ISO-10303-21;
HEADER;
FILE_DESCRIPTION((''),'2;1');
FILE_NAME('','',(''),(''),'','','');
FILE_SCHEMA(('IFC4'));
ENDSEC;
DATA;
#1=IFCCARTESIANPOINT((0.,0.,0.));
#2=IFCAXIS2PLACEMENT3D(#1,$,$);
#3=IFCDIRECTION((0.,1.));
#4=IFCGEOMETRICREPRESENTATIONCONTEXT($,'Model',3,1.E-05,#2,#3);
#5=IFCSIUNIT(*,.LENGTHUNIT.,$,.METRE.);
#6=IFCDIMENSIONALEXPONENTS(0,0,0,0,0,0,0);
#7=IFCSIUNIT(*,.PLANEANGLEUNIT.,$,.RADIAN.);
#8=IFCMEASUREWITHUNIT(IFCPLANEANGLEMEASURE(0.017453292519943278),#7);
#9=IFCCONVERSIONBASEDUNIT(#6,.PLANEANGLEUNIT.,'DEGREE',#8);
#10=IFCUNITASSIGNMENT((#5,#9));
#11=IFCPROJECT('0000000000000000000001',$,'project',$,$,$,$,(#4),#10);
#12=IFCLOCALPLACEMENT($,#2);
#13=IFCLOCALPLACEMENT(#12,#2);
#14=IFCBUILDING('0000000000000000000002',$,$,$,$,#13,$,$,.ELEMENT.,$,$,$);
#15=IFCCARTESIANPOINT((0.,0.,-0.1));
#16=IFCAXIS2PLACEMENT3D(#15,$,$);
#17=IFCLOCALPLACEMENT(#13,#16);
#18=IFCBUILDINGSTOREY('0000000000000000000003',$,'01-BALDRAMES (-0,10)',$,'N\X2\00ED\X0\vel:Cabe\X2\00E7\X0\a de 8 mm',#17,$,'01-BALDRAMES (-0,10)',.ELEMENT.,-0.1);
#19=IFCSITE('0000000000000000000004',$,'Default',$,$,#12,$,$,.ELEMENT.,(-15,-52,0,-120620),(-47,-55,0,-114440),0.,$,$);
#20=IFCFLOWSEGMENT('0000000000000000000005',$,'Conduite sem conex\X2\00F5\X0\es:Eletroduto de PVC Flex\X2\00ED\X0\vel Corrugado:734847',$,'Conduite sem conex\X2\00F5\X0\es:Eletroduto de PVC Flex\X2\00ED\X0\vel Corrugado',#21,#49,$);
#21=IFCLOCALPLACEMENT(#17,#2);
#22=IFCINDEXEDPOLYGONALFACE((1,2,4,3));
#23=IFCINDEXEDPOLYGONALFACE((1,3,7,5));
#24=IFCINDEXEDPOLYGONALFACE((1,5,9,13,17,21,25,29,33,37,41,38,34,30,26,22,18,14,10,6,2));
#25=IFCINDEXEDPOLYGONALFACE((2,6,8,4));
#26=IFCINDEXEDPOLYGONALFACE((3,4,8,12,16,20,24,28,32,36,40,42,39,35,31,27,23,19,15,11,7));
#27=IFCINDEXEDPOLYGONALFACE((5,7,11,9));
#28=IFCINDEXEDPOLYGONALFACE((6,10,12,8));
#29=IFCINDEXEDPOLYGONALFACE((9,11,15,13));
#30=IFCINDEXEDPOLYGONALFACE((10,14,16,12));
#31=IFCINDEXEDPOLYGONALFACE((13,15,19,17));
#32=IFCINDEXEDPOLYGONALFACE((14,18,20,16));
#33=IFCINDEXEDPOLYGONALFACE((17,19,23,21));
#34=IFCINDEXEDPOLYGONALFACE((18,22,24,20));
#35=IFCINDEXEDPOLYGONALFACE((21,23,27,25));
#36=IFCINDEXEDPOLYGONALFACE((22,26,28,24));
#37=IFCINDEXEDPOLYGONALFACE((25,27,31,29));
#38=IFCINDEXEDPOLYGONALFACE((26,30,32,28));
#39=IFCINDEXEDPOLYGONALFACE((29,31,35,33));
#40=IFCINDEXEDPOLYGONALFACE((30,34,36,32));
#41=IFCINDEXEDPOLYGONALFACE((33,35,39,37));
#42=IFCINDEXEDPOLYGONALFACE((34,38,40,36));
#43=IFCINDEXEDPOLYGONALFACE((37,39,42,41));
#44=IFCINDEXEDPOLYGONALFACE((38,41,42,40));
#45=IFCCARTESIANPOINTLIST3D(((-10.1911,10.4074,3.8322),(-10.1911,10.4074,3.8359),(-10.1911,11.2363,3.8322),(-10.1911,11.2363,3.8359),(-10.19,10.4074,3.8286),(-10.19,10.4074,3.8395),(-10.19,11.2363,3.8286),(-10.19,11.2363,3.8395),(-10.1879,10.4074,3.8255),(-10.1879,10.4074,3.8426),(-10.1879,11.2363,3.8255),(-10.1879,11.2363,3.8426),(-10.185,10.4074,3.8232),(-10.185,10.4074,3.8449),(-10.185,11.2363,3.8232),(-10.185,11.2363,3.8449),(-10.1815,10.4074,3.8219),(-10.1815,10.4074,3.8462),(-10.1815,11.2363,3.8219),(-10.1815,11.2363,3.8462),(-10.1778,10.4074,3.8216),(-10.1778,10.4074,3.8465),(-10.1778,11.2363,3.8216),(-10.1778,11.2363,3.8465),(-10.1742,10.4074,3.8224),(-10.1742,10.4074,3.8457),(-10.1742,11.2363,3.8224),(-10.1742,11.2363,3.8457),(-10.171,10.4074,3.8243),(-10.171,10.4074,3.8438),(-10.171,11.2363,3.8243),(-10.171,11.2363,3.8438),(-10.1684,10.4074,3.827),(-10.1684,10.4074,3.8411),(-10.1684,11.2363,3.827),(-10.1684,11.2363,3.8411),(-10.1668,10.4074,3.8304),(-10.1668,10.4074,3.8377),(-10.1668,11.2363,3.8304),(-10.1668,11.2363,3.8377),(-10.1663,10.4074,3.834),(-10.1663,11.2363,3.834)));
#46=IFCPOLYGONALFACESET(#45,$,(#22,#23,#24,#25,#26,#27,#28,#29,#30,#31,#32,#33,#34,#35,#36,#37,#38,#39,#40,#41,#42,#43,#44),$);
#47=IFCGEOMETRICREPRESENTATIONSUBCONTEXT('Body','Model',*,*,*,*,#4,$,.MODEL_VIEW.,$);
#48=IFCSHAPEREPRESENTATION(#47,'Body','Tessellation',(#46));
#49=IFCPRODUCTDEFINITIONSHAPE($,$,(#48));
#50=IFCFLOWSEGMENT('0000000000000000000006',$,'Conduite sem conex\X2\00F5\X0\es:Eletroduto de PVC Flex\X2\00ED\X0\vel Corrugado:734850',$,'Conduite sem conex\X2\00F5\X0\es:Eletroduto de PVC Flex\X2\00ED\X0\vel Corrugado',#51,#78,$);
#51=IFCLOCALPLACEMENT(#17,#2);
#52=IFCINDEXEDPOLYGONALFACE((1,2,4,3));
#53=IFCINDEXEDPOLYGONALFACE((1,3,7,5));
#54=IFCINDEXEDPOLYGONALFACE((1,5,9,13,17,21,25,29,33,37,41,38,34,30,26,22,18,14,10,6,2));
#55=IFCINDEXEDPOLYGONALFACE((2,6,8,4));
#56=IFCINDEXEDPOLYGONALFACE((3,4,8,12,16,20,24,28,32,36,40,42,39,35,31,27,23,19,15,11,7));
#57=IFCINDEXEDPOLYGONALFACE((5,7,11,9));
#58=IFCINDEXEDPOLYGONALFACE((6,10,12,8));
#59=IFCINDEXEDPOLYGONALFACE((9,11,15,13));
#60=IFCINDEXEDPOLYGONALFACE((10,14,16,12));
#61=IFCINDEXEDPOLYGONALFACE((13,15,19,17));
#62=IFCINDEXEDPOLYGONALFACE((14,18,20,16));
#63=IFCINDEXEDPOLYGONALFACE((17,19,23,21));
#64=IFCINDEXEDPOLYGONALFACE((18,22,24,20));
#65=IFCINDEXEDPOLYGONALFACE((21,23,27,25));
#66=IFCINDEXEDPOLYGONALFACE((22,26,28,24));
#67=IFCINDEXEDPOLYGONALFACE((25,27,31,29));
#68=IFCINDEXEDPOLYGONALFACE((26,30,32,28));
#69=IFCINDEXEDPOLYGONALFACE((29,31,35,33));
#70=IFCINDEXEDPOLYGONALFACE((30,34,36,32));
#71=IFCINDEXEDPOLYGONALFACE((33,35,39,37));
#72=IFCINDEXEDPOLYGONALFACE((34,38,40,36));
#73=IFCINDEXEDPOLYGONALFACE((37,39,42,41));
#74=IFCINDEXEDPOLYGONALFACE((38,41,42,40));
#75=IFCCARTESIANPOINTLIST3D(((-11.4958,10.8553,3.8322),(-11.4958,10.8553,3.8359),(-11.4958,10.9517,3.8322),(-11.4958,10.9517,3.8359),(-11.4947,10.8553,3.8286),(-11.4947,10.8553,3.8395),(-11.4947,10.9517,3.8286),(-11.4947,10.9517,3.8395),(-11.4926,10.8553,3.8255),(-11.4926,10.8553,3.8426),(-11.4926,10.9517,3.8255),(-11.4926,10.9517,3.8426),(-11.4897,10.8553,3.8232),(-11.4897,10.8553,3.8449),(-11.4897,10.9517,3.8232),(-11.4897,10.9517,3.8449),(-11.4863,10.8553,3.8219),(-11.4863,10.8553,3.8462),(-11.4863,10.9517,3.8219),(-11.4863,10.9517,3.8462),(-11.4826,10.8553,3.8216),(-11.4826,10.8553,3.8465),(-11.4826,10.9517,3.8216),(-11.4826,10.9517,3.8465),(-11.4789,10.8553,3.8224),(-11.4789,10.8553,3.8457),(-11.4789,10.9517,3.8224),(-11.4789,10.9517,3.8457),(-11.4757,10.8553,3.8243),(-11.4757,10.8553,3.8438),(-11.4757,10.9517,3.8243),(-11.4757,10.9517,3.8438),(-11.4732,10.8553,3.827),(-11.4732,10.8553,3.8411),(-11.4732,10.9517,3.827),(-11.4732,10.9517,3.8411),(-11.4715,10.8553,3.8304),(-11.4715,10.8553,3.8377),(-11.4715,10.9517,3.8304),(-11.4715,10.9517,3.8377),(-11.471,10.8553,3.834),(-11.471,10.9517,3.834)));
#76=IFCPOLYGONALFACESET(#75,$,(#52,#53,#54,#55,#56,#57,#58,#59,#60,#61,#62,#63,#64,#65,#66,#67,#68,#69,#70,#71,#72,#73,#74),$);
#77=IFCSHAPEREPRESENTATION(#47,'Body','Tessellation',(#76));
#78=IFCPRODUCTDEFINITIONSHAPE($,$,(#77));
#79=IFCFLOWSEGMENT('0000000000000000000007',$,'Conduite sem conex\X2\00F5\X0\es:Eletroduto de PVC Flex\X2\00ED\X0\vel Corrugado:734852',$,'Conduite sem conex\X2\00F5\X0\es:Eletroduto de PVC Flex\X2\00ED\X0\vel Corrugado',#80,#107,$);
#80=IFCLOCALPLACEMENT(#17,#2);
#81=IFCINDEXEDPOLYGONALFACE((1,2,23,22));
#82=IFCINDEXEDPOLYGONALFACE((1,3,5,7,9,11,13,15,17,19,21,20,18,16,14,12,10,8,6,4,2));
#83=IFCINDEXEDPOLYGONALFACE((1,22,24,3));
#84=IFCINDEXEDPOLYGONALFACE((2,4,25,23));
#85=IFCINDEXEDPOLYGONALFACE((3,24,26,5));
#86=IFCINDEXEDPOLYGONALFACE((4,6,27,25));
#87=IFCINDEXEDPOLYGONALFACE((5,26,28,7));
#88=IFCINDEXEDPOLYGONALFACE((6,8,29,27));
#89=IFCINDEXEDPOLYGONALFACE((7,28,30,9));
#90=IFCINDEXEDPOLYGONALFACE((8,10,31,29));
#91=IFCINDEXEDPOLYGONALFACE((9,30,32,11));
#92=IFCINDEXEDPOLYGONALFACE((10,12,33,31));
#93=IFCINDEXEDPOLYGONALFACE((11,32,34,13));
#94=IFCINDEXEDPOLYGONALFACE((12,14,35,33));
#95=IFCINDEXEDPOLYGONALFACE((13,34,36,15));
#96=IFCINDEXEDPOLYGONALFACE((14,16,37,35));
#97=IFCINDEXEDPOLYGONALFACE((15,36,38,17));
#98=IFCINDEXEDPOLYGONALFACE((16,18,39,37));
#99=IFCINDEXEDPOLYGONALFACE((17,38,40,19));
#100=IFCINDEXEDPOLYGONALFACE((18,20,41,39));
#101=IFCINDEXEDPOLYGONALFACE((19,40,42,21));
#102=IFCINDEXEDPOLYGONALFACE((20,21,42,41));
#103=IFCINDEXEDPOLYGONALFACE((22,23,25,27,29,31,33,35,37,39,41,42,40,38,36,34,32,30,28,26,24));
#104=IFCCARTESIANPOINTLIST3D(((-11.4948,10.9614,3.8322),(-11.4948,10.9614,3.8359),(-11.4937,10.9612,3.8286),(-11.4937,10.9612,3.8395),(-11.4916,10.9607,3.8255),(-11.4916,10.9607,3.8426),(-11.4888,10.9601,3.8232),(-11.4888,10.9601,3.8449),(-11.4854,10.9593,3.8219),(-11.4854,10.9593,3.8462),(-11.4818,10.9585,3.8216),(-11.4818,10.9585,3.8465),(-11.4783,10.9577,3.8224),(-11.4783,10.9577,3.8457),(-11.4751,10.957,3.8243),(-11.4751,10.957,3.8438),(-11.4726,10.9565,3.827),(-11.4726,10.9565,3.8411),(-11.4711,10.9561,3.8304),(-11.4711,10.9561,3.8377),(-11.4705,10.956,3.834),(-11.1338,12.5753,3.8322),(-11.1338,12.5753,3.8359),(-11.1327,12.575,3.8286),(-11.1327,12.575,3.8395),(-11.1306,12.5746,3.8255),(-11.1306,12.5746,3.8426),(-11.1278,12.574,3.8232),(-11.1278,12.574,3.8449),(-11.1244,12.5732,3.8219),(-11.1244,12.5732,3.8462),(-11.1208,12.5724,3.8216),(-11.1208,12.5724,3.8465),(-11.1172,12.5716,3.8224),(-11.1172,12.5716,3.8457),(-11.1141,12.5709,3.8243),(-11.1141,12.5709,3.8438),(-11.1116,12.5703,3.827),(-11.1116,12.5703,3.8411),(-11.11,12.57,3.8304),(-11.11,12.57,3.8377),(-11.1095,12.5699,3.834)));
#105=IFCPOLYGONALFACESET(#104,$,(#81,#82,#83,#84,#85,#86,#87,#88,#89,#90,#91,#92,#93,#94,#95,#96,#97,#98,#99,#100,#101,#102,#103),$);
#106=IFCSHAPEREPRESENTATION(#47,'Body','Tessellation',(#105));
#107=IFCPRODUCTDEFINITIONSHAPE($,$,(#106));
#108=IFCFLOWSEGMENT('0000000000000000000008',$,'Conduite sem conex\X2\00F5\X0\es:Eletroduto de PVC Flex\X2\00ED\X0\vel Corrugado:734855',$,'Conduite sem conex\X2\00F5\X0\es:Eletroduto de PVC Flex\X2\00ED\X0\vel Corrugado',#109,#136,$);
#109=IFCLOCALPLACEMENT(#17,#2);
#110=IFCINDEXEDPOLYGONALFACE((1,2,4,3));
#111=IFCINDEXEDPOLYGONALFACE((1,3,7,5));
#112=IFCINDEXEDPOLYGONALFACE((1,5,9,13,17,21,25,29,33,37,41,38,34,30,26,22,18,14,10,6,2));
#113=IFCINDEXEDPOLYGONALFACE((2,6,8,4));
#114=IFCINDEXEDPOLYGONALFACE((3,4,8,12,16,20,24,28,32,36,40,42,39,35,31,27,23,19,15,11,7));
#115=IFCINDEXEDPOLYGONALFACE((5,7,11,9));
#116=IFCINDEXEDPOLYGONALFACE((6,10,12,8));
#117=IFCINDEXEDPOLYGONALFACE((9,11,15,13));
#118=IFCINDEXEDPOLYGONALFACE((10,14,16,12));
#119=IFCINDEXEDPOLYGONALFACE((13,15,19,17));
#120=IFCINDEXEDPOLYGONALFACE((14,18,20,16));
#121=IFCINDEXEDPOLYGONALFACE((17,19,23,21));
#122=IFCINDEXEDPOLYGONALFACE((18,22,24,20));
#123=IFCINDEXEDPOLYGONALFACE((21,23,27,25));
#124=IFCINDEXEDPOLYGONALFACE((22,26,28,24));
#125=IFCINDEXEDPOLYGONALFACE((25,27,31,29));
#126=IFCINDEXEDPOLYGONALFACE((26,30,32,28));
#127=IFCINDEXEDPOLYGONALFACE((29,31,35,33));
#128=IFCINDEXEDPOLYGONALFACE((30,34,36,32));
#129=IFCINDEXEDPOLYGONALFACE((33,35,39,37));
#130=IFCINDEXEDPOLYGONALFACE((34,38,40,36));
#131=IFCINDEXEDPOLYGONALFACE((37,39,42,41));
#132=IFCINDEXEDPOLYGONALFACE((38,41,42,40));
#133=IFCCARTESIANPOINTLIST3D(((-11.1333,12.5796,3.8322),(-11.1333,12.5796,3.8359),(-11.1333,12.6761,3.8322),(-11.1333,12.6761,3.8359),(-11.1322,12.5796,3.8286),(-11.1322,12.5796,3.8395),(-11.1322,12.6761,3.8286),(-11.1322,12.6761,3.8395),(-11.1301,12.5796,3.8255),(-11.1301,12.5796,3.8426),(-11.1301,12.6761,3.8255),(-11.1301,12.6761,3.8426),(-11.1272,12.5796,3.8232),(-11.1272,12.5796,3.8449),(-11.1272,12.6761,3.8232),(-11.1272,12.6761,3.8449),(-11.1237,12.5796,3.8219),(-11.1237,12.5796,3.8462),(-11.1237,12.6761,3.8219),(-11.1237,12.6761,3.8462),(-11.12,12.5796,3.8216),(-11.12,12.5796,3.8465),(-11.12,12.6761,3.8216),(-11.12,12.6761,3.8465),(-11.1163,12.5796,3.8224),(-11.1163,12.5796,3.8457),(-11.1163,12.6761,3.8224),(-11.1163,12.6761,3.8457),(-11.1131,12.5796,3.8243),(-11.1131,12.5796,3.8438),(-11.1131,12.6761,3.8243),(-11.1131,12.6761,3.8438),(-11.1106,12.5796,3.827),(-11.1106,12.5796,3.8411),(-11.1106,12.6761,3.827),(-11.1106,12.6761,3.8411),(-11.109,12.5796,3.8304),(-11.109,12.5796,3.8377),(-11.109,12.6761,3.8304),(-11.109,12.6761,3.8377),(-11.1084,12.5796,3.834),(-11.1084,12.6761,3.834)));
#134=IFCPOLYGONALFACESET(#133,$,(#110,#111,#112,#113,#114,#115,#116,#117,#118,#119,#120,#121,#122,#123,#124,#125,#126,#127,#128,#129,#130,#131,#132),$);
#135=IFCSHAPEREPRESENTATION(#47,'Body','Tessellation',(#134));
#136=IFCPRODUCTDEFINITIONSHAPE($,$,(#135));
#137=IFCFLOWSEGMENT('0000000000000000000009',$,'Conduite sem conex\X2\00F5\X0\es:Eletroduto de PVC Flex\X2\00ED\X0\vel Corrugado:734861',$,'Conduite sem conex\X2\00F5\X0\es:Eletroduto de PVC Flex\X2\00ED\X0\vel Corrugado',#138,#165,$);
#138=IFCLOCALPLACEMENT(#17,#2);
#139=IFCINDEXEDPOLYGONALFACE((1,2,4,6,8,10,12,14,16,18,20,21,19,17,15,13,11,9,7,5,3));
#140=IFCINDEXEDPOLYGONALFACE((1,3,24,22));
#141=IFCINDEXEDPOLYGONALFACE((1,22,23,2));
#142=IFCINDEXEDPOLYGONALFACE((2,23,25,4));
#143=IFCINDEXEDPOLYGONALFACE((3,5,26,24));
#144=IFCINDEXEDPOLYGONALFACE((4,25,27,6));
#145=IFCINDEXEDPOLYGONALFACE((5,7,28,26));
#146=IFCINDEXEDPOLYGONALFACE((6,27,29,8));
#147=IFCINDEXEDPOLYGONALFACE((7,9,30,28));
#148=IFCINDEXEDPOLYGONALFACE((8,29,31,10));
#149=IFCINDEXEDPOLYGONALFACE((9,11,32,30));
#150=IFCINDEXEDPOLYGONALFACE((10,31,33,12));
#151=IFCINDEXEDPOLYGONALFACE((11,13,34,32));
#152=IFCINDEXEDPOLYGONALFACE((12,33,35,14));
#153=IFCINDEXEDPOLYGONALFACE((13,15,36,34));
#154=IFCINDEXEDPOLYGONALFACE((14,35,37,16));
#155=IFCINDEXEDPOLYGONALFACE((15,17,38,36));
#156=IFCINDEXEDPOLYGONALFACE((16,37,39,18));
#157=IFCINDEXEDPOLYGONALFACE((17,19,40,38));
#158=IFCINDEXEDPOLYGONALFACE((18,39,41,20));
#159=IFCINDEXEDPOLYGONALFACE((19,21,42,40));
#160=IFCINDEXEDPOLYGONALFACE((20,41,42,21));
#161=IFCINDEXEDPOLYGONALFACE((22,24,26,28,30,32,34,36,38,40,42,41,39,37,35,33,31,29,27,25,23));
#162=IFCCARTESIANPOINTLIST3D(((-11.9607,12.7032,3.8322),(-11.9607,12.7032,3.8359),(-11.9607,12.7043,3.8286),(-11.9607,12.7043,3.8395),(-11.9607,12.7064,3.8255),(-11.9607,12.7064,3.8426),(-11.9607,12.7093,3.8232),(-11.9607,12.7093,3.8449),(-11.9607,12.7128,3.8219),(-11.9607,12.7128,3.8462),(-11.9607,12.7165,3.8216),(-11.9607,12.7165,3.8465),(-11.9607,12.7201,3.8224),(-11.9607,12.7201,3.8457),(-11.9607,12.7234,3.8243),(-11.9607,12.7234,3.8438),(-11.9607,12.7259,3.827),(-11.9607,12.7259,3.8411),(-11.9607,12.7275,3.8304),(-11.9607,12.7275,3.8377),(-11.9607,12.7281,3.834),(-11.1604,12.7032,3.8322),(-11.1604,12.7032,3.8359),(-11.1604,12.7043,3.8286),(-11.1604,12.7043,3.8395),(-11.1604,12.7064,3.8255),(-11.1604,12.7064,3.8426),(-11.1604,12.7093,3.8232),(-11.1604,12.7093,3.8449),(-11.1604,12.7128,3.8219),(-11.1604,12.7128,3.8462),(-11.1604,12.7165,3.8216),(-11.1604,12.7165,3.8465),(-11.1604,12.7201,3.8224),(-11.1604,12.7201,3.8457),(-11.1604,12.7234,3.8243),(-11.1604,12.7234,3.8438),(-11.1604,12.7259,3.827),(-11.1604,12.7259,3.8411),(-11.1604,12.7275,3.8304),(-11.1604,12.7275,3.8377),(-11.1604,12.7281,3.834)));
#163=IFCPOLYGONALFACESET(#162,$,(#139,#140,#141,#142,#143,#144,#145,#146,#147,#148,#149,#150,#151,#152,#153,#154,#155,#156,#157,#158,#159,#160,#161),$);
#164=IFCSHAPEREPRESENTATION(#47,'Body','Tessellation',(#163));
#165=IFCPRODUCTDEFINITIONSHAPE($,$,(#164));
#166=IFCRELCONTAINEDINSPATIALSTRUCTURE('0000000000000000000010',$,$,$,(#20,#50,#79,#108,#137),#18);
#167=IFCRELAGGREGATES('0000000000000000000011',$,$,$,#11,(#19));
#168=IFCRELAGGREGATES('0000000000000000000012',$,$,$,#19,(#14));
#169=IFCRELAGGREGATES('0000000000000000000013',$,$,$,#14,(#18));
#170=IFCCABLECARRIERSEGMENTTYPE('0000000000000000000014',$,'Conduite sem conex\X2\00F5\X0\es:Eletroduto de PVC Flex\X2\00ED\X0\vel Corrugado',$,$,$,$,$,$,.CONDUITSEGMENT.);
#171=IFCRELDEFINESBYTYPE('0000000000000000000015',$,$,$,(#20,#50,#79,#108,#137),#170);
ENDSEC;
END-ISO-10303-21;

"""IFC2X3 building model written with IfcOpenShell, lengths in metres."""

from ifc_helpers import new_model, entity, si_unit, converted_unit, direction, frame, frame_2d, origin, origin_2d_with_axis, place, context, subcontext, project, spatial, circle, extrude, type_object, element, save


model = new_model("IFC2X3")

# Units and contexts
model_context = context("Model", 3, precision=1e-05, world=origin(), true_north=direction((0.0, 1.0)))
body_context = subcontext(model_context, "Body", "Model", "MODEL_VIEW")
ifc_project = project(units=[si_unit("LENGTHUNIT", "METRE"), converted_unit("PLANEANGLEUNIT", "DEGREE", entity("IfcPlaneAngleMeasure", 0.017453292519943278), si_unit("PLANEANGLEUNIT", "RADIAN"), dimensions=[0, 0, 0, 0, 0, 0, 0])], contexts=[model_context])

# Site, building, storey
site_placement = place(None, origin())
site = spatial("IfcSite", under=ifc_project, at=site_placement, Name="Default", CompositionType="ELEMENT", RefLatitude=(-15, -52, 0, -120620), RefLongitude=(-47, -55, 0, -114440), RefElevation=0.0)
building_placement = place(site_placement, origin())
building = spatial("IfcBuilding", under=site, at=building_placement, CompositionType="ELEMENT")
storey_placement = place(building_placement, frame((0.0, 0.0, -0.1)))
storey = spatial("IfcBuildingStorey", under=building, at=storey_placement, Name="01-BALDRAMES (-0,10)", ObjectType="Nível:Cabeça de 8 mm", LongName="01-BALDRAMES (-0,10)", CompositionType="ELEMENT", Elevation=-0.1)

# Flow segments
cable_carrier_segment_type = type_object("IfcCableCarrierSegmentType", Name="Conduite sem conexões:Eletroduto de PVC Flexível Corrugado", PredefinedType="CONDUITSEGMENT")
flow_segment_1_placement = place(storey_placement, origin())
element("IfcFlowSegment", 1, at=flow_segment_1_placement, inside=storey, type_object=cable_carrier_segment_type, Name="Conduite sem conexões:Eletroduto de PVC Flexível Corrugado:734847", ObjectType="Conduite sem conexões:Eletroduto de PVC Flexível Corrugado", context=body_context, shape_type="SweptSolid", body=[
    extrude(circle(Radius=0.0125, at=origin_2d_with_axis()), frame((-10.1788, 10.4074, 3.834), z_axis=(0.0, 1.0, 0.0), x_axis=(1.0, 0.0, 0.0)), (0.0, 0.0, 1.0), 0.8289),
])
flow_segment_2_placement = place(storey_placement, origin())
element("IfcFlowSegment", 2, at=flow_segment_2_placement, inside=storey, type_object=cable_carrier_segment_type, Name="Conduite sem conexões:Eletroduto de PVC Flexível Corrugado:734850", ObjectType="Conduite sem conexões:Eletroduto de PVC Flexível Corrugado", context=body_context, shape_type="SweptSolid", body=[
    extrude(circle(Radius=0.0125, at=origin_2d_with_axis()), frame((-11.4835, 10.8553, 3.834), z_axis=(0.0, 1.0, 0.0), x_axis=(1.0, 0.0, 0.0)), (0.0, 0.0, 1.0), 0.0964),
])
flow_segment_3_placement = place(storey_placement, origin())
element("IfcFlowSegment", 3, at=flow_segment_3_placement, inside=storey, type_object=cable_carrier_segment_type, Name="Conduite sem conexões:Eletroduto de PVC Flexível Corrugado:734852", ObjectType="Conduite sem conexões:Eletroduto de PVC Flexível Corrugado", context=body_context, shape_type="SweptSolid", body=[
    extrude(circle(Radius=0.0125, at=origin_2d_with_axis()), frame((-11.4827, 10.9587, 3.834), z_axis=(0.218303, 0.975881, 0.0), x_axis=(0.975881, -0.218303, 0.0)), (0.0, 0.0, 1.0), 1.6537),
])
flow_segment_4_placement = place(storey_placement, origin())
element("IfcFlowSegment", 4, at=flow_segment_4_placement, inside=storey, type_object=cable_carrier_segment_type, Name="Conduite sem conexões:Eletroduto de PVC Flexível Corrugado:734855", ObjectType="Conduite sem conexões:Eletroduto de PVC Flexível Corrugado", context=body_context, shape_type="SweptSolid", body=[
    extrude(circle(Radius=0.0125, at=origin_2d_with_axis()), frame((-11.1209, 12.5796, 3.834), z_axis=(0.0, 1.0, 0.0), x_axis=(1.0, 0.0, 0.0)), (0.0, 0.0, 1.0), 0.0964),
])
flow_segment_5_placement = place(storey_placement, origin())
element("IfcFlowSegment", 5, at=flow_segment_5_placement, inside=storey, type_object=cable_carrier_segment_type, Name="Conduite sem conexões:Eletroduto de PVC Flexível Corrugado:734861", ObjectType="Conduite sem conexões:Eletroduto de PVC Flexível Corrugado", context=body_context, shape_type="SweptSolid", body=[
    extrude(circle(Radius=0.0125, at=frame_2d((0.0, 0.0), x_axis=(1.0, 0.0))), frame((-11.9607, 12.7156, 3.834), z_axis=(1.0, 0.0, 0.0), x_axis=(0.0, 1.0, 0.0)), (0.0, 0.0, 1.0), 0.8003),
])

save(model, "model.ifc")
